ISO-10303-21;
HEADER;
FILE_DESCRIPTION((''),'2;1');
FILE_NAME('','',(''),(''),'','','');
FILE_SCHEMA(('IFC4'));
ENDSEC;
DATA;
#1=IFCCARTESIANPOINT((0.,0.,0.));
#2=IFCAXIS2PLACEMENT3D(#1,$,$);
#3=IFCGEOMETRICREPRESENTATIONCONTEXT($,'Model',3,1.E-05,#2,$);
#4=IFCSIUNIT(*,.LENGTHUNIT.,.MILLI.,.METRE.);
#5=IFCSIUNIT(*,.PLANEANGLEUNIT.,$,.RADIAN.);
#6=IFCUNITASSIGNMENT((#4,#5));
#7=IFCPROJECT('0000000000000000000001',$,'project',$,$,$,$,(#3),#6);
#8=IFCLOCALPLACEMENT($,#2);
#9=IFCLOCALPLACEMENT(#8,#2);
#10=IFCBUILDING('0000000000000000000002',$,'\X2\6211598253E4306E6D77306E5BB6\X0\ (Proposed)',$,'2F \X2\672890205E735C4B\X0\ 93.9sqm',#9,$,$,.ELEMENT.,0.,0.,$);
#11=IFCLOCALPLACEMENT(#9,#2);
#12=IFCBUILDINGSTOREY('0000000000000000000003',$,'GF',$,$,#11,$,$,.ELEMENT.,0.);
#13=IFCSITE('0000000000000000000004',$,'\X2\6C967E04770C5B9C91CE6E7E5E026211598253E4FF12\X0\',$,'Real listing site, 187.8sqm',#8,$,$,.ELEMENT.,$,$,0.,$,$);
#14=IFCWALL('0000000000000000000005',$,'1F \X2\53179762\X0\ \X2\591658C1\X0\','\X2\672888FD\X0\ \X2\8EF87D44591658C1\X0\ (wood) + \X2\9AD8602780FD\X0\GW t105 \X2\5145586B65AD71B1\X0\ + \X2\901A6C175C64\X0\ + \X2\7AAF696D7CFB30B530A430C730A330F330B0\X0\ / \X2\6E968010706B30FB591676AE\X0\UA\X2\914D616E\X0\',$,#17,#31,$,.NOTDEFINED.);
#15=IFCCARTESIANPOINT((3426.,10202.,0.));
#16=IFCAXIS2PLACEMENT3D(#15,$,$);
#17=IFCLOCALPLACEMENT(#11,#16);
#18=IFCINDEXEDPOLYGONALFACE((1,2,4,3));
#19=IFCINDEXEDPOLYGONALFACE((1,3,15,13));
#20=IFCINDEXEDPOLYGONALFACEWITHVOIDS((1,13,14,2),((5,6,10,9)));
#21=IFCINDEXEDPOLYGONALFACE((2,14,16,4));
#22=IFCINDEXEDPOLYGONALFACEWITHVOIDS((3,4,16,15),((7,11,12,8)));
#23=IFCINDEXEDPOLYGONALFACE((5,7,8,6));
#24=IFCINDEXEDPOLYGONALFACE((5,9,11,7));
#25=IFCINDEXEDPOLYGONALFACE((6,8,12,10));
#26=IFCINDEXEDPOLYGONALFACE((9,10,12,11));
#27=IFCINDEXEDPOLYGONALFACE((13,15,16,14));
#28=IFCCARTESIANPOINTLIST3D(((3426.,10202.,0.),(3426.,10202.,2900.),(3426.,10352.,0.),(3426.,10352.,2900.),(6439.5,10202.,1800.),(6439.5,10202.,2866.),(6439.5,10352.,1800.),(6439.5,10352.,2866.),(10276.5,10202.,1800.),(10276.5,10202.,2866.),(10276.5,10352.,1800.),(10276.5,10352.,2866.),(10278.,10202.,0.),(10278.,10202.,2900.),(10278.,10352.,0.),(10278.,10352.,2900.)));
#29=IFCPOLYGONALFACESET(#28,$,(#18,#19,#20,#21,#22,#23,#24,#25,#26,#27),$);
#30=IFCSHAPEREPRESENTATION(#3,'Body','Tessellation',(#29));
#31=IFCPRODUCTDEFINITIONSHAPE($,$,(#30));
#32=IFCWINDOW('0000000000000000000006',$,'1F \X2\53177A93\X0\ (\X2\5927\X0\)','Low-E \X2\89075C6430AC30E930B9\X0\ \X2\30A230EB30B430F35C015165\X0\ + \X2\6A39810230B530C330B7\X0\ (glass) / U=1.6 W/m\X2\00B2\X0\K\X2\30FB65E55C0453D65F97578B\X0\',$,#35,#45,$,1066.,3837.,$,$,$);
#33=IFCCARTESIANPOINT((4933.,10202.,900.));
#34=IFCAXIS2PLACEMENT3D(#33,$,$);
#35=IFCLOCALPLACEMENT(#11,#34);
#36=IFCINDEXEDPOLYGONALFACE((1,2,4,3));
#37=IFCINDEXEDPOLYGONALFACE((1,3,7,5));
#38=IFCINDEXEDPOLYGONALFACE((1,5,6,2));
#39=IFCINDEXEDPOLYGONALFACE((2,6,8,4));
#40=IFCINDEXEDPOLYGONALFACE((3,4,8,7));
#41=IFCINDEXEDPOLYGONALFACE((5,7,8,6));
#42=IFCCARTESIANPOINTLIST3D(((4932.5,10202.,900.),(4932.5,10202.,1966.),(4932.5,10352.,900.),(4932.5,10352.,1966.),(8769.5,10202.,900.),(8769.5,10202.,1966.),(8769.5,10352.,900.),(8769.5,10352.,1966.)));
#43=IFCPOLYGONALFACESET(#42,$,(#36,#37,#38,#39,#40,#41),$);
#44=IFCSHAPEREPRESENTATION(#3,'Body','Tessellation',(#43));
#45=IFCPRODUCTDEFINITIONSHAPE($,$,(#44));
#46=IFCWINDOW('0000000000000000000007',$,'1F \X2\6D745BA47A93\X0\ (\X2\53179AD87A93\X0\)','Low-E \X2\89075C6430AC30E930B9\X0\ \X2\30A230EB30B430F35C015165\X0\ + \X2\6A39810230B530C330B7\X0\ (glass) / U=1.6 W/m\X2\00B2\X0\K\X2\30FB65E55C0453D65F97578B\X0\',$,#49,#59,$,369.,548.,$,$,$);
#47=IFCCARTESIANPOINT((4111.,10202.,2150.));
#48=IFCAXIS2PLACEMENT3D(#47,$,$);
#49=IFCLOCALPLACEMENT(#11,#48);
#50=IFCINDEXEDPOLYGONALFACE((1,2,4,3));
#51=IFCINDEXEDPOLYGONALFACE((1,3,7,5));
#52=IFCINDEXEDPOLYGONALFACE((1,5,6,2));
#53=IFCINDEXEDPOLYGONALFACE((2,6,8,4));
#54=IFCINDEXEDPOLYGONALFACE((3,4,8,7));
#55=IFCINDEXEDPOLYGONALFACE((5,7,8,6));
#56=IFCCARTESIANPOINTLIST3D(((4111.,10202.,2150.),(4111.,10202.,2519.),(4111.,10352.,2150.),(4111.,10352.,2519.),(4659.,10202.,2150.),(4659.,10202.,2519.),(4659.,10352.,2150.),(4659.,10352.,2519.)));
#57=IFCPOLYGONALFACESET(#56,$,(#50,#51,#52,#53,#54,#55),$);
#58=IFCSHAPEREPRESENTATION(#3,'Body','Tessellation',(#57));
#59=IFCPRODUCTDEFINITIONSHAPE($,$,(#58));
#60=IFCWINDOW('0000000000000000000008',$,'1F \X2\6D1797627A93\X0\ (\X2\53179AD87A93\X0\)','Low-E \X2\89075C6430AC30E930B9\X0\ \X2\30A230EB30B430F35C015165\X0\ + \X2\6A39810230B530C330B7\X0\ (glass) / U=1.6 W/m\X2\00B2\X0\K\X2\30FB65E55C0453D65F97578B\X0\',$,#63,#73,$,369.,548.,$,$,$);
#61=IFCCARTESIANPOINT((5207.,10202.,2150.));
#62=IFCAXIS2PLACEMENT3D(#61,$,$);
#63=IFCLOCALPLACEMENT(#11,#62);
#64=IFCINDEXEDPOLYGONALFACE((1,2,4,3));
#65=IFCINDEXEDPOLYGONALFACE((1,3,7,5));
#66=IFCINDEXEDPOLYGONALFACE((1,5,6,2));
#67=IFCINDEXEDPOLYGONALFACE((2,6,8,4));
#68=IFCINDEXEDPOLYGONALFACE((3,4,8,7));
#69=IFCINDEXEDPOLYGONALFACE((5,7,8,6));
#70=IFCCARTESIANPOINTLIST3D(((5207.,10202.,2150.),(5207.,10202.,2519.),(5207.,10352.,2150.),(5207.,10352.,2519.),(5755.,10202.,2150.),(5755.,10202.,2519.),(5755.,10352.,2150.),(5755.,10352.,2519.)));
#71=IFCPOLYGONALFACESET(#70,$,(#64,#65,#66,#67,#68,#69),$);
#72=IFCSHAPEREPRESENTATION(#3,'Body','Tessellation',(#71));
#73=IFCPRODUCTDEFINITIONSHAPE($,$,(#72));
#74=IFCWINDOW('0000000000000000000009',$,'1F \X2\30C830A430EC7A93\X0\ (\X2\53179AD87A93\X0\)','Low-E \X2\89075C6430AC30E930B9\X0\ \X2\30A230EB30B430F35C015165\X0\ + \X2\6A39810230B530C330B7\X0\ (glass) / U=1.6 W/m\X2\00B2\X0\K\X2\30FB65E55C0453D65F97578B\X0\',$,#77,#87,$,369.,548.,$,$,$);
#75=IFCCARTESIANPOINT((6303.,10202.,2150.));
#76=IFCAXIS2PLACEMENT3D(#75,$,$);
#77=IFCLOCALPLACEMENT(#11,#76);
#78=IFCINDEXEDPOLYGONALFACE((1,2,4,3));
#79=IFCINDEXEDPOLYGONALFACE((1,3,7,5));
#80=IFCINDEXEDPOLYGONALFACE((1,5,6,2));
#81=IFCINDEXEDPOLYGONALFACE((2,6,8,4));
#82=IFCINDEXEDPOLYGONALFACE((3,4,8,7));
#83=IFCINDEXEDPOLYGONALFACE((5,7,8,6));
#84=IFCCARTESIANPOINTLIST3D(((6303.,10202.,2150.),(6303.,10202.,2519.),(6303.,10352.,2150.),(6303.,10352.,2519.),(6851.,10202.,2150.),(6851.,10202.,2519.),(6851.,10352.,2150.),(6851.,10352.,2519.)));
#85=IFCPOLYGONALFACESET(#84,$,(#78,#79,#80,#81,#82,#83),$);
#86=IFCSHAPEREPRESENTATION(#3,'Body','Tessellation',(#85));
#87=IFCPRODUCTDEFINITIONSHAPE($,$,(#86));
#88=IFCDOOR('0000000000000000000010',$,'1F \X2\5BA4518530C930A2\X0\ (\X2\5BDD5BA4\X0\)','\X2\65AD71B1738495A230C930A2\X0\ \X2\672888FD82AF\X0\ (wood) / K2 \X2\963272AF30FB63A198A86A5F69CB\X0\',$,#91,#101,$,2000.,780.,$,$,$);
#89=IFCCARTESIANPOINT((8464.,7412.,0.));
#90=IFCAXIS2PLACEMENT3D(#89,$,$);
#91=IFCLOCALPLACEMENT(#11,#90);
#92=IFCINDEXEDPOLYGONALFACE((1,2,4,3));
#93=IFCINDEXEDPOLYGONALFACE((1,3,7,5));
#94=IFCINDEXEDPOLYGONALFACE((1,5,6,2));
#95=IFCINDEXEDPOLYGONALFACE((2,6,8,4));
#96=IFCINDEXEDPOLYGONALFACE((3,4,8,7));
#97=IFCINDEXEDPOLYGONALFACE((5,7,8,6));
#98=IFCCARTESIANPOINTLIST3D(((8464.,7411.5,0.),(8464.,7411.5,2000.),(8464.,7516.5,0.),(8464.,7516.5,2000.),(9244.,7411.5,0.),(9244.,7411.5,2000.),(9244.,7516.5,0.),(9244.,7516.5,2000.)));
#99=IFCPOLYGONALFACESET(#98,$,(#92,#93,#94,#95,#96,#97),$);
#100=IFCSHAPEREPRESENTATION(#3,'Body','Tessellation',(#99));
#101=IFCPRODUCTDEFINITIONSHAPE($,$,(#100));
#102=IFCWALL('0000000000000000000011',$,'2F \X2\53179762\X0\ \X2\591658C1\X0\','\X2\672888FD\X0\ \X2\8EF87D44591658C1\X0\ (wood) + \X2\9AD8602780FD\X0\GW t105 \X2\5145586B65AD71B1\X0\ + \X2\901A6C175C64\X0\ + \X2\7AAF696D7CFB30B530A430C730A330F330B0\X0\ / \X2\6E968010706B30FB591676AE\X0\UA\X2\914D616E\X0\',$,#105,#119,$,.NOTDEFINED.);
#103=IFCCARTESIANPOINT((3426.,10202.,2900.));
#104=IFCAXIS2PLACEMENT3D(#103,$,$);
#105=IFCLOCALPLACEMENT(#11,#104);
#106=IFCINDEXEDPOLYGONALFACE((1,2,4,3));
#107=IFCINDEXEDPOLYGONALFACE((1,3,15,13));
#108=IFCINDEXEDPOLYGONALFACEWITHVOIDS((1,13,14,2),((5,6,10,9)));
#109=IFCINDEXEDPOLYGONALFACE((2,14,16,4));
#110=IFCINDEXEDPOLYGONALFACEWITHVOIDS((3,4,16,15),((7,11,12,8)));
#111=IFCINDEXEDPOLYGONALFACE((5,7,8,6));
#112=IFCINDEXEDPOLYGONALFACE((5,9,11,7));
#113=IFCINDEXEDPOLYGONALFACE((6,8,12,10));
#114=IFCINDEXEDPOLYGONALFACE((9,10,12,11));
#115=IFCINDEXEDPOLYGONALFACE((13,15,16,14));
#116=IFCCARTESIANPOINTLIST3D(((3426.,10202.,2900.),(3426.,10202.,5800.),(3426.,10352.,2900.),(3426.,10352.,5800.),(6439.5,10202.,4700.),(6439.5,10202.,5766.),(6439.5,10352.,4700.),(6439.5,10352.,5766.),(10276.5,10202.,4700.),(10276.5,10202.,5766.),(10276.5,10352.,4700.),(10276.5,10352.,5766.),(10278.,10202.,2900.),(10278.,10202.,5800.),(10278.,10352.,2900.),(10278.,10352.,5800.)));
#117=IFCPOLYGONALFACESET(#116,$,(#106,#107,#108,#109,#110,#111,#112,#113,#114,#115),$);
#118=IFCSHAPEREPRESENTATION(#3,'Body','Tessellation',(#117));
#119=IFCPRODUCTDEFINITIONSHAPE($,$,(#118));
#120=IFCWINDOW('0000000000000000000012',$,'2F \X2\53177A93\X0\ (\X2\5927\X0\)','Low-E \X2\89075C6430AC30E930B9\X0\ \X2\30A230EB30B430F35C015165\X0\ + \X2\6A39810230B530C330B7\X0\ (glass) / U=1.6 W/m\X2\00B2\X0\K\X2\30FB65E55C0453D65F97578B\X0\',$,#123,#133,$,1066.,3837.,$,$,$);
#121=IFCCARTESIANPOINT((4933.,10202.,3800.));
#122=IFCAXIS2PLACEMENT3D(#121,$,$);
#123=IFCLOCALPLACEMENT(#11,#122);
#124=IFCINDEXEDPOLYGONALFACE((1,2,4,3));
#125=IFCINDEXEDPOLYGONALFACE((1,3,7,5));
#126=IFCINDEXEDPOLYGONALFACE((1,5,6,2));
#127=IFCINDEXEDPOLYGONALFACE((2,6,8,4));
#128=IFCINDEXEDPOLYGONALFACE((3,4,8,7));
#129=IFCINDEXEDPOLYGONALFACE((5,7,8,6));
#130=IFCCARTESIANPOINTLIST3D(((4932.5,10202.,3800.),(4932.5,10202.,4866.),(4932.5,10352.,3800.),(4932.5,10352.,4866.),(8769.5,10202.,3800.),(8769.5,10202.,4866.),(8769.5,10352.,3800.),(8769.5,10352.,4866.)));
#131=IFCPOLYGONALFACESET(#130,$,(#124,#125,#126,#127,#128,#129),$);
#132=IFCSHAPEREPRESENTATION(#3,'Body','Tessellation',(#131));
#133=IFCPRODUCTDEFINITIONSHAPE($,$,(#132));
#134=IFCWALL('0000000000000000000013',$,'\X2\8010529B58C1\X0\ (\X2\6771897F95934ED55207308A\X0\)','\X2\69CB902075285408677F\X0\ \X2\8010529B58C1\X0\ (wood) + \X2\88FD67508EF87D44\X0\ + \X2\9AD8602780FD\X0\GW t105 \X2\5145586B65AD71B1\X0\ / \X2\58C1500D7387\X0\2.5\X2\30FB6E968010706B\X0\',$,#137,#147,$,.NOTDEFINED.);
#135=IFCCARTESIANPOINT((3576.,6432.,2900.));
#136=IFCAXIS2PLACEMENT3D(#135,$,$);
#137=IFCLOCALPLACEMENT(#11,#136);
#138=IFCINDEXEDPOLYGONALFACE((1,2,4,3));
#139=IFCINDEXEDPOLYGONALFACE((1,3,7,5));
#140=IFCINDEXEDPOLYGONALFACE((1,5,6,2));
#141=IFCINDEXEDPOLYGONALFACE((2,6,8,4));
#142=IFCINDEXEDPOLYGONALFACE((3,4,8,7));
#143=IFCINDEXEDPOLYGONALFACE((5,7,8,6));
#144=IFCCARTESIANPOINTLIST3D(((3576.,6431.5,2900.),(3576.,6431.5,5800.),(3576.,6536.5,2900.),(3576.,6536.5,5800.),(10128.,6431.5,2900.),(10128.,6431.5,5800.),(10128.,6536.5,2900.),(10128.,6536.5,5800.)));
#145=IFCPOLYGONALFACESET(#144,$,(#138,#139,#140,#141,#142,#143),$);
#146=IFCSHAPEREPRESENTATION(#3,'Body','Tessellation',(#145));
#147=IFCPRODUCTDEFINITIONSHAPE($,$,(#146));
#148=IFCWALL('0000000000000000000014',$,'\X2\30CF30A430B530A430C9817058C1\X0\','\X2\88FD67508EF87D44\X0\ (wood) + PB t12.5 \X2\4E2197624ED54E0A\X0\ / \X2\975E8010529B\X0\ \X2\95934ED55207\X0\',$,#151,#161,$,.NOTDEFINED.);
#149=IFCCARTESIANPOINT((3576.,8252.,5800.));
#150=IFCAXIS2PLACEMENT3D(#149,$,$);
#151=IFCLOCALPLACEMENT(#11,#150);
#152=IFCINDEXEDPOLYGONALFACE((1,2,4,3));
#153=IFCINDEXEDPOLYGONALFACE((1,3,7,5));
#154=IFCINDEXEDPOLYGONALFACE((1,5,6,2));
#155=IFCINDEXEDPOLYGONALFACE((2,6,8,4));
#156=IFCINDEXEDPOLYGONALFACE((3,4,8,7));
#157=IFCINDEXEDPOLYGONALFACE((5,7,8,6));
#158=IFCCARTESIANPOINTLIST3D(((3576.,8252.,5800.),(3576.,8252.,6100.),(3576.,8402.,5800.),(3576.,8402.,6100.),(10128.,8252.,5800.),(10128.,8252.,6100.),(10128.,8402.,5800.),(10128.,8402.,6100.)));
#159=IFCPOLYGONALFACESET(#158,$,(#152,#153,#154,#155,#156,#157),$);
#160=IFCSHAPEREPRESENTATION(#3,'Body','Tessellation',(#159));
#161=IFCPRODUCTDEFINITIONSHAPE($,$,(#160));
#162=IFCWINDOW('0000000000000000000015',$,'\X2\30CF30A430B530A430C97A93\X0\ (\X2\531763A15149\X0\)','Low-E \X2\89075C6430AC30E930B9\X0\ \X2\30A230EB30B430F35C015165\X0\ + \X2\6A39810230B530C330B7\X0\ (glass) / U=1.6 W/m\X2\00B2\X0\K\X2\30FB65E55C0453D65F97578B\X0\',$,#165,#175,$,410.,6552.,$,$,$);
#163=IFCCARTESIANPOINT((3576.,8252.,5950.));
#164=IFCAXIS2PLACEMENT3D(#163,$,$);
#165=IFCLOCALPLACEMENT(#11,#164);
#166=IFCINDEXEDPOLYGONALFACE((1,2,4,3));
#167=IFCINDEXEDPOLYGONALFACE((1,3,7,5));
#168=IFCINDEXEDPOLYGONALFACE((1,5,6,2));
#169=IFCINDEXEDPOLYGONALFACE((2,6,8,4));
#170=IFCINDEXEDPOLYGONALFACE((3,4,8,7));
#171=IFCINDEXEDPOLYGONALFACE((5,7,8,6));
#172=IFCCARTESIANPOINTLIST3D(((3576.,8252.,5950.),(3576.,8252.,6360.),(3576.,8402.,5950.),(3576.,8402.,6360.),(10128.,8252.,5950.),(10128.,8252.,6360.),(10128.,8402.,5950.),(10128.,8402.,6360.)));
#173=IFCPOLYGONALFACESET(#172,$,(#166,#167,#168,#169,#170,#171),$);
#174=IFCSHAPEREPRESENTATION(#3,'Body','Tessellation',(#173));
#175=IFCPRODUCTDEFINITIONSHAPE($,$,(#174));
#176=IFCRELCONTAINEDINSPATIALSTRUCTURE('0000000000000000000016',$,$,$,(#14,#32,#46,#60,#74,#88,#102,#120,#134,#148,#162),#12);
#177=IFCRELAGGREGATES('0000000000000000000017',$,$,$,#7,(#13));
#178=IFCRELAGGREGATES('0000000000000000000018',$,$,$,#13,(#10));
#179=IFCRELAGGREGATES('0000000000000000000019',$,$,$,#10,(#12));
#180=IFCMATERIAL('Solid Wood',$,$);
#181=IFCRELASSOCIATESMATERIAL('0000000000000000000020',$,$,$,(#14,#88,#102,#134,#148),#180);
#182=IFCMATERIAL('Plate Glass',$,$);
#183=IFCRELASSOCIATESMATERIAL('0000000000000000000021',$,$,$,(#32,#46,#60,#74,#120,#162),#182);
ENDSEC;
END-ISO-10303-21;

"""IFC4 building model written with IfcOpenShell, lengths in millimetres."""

from ifc_helpers import new_model, si_unit, frame, frame_2d, origin, place, context, project, spatial, rectangle, extrude, material, element, fill, save


model = new_model("IFC4")

# Units and contexts
model_context = context("Model", 3, precision=1e-05, world=origin())
ifc_project = project(units=[si_unit("LENGTHUNIT", "METRE", prefix="MILLI"), si_unit("PLANEANGLEUNIT", "RADIAN")], contexts=[model_context])

# Site, building, storey
site_placement = place(None, origin())
site = spatial("IfcSite", under=ifc_project, at=site_placement, Name="沖縄県宜野湾市我如古２", ObjectType="Real listing site, 187.8sqm", CompositionType="ELEMENT", RefElevation=0.0)
building_placement = place(site_placement, origin())
building = spatial("IfcBuilding", under=site, at=building_placement, Name="我如古の海の家 (Proposed)", ObjectType="2F 木造平屋 93.9sqm", CompositionType="ELEMENT", ElevationOfRefHeight=0.0, ElevationOfTerrain=0.0)
storey_placement = place(building_placement, origin())
storey = spatial("IfcBuildingStorey", under=building, at=storey_placement, Name="GF", CompositionType="ELEMENT", Elevation=0.0)

# Wall, openings, windows
ifc_material_1 = material(Name="Solid Wood")
wall_1_placement = place(storey_placement, frame((3426.0, 10202.0, 0.0)))
wall_1 = element("IfcWall", 1, at=wall_1_placement, inside=storey, material=ifc_material_1, Name="1F 北面 外壁", Description="木製 軸組外壁 (wood) + 高性能GW t105 充填断熱 + 通気層 + 窯業系サイディング / 準耐火・外皮UA配慮", PredefinedType="NOTDEFINED", context=model_context, shape_type="SweptSolid", body=[
    extrude(rectangle(XDim=6852.0, YDim=150.0, at=frame_2d((3426.0, 75.0))), frame((3426.0, 10202.0, 0.0)), (0.0, 0.0, 1.0), 2900.0),
])
opening_1_placement = place(storey_placement, frame((4933.0, 10202.0, 900.0)))
opening_1 = element("IfcOpeningElement", 2, at=opening_1_placement, cuts=wall_1, PredefinedType="NOTDEFINED", context=model_context, shape_type="SweptSolid", body=[
    extrude(rectangle(XDim=3837.0, YDim=150.0, at=frame_2d((1918.0, 75.0))), frame((4933.0, 10202.0, 900.0)), (0.0, 0.0, 1.0), 1066.0),
])
opening_2_placement = place(storey_placement, frame((4111.0, 10202.0, 2150.0)))
opening_2 = element("IfcOpeningElement", 3, at=opening_2_placement, cuts=wall_1, PredefinedType="NOTDEFINED", context=model_context, shape_type="SweptSolid", body=[
    extrude(rectangle(XDim=548.0, YDim=150.0, at=frame_2d((274.0, 75.0))), frame((4111.0, 10202.0, 2150.0)), (0.0, 0.0, 1.0), 369.0),
])
opening_3_placement = place(storey_placement, frame((5207.0, 10202.0, 2150.0)))
opening_3 = element("IfcOpeningElement", 4, at=opening_3_placement, cuts=wall_1, PredefinedType="NOTDEFINED", context=model_context, shape_type="SweptSolid", body=[
    extrude(rectangle(XDim=548.0, YDim=150.0, at=frame_2d((274.0, 75.0))), frame((5207.0, 10202.0, 2150.0)), (0.0, 0.0, 1.0), 369.0),
])
opening_4_placement = place(storey_placement, frame((6303.0, 10202.0, 2150.0)))
opening_4 = element("IfcOpeningElement", 5, at=opening_4_placement, cuts=wall_1, PredefinedType="NOTDEFINED", context=model_context, shape_type="SweptSolid", body=[
    extrude(rectangle(XDim=548.0, YDim=150.0, at=frame_2d((274.0, 75.0))), frame((6303.0, 10202.0, 2150.0)), (0.0, 0.0, 1.0), 369.0),
])
ifc_material_2 = material(Name="Plate Glass")
window_1_placement = place(storey_placement, frame((4933.0, 10202.0, 900.0)))
window_1 = element("IfcWindow", 6, at=window_1_placement, inside=storey, material=ifc_material_2, Name="1F 北窓 (大)", Description="Low-E 複層ガラス アルゴン封入 + 樹脂サッシ (glass) / U=1.6 W/m²K・日射取得型", OverallHeight=1066.0, OverallWidth=3837.0, context=model_context, shape_type="SweptSolid", body=[
    extrude(rectangle(XDim=3837.0, YDim=150.0, at=frame_2d((1918.0, 75.0))), frame((4933.0, 10202.0, 900.0)), (0.0, 0.0, 1.0), 1066.0),
])
fill(opening_1, window_1)
window_2_placement = place(storey_placement, frame((4111.0, 10202.0, 2150.0)))
window_2 = element("IfcWindow", 7, at=window_2_placement, inside=storey, material=ifc_material_2, Name="1F 浴室窓 (北高窓)", Description="Low-E 複層ガラス アルゴン封入 + 樹脂サッシ (glass) / U=1.6 W/m²K・日射取得型", OverallHeight=369.0, OverallWidth=548.0, context=model_context, shape_type="SweptSolid", body=[
    extrude(rectangle(XDim=548.0, YDim=150.0, at=frame_2d((274.0, 75.0))), frame((4111.0, 10202.0, 2150.0)), (0.0, 0.0, 1.0), 369.0),
])
fill(opening_2, window_2)
window_3_placement = place(storey_placement, frame((5207.0, 10202.0, 2150.0)))
window_3 = element("IfcWindow", 8, at=window_3_placement, inside=storey, material=ifc_material_2, Name="1F 洗面窓 (北高窓)", Description="Low-E 複層ガラス アルゴン封入 + 樹脂サッシ (glass) / U=1.6 W/m²K・日射取得型", OverallHeight=369.0, OverallWidth=548.0, context=model_context, shape_type="SweptSolid", body=[
    extrude(rectangle(XDim=548.0, YDim=150.0, at=frame_2d((274.0, 75.0))), frame((5207.0, 10202.0, 2150.0)), (0.0, 0.0, 1.0), 369.0),
])
fill(opening_3, window_3)
window_4_placement = place(storey_placement, frame((6303.0, 10202.0, 2150.0)))
window_4 = element("IfcWindow", 9, at=window_4_placement, inside=storey, material=ifc_material_2, Name="1F トイレ窓 (北高窓)", Description="Low-E 複層ガラス アルゴン封入 + 樹脂サッシ (glass) / U=1.6 W/m²K・日射取得型", OverallHeight=369.0, OverallWidth=548.0, context=model_context, shape_type="SweptSolid", body=[
    extrude(rectangle(XDim=548.0, YDim=150.0, at=frame_2d((274.0, 75.0))), frame((6303.0, 10202.0, 2150.0)), (0.0, 0.0, 1.0), 369.0),
])
fill(opening_4, window_4)

# Door
door_1_placement = place(storey_placement, frame((8464.0, 7412.0, 0.0)))
element("IfcDoor", 10, at=door_1_placement, inside=storey, material=ifc_material_1, Name="1F 室内ドア (寝室)", Description="断熱玄関ドア 木製芯 (wood) / K2 防犯・採風機構", OverallHeight=2000.0, OverallWidth=780.0, context=model_context, shape_type="SweptSolid", body=[
    extrude(rectangle(XDim=780.0, YDim=105.0, at=frame_2d((390.0, 52.0))), frame((8464.0, 7412.0, 0.0)), (0.0, 0.0, 1.0), 2000.0),
])

# Wall, opening, window
wall_2_placement = place(storey_placement, frame((3426.0, 10202.0, 2900.0)))
wall_2 = element("IfcWall", 11, at=wall_2_placement, inside=storey, material=ifc_material_1, Name="2F 北面 外壁", Description="木製 軸組外壁 (wood) + 高性能GW t105 充填断熱 + 通気層 + 窯業系サイディング / 準耐火・外皮UA配慮", PredefinedType="NOTDEFINED", context=model_context, shape_type="SweptSolid", body=[
    extrude(rectangle(XDim=6852.0, YDim=150.0, at=frame_2d((3426.0, 75.0))), frame((3426.0, 10202.0, 2900.0)), (0.0, 0.0, 1.0), 2900.0),
])
opening_5_placement = place(storey_placement, frame((4933.0, 10202.0, 3800.0)))
opening_5 = element("IfcOpeningElement", 12, at=opening_5_placement, cuts=wall_2, PredefinedType="NOTDEFINED", context=model_context, shape_type="SweptSolid", body=[
    extrude(rectangle(XDim=3837.0, YDim=150.0, at=frame_2d((1918.0, 75.0))), frame((4933.0, 10202.0, 3800.0)), (0.0, 0.0, 1.0), 1066.0),
])
window_5_placement = place(storey_placement, frame((4933.0, 10202.0, 3800.0)))
window_5 = element("IfcWindow", 13, at=window_5_placement, inside=storey, material=ifc_material_2, Name="2F 北窓 (大)", Description="Low-E 複層ガラス アルゴン封入 + 樹脂サッシ (glass) / U=1.6 W/m²K・日射取得型", OverallHeight=1066.0, OverallWidth=3837.0, context=model_context, shape_type="SweptSolid", body=[
    extrude(rectangle(XDim=3837.0, YDim=150.0, at=frame_2d((1918.0, 75.0))), frame((4933.0, 10202.0, 3800.0)), (0.0, 0.0, 1.0), 1066.0),
])
fill(opening_5, window_5)

# Wall
wall_3_placement = place(storey_placement, frame((3576.0, 6432.0, 2900.0)))
element("IfcWall", 14, at=wall_3_placement, inside=storey, material=ifc_material_1, Name="耐力壁 (東西間仕切り)", Description="構造用合板 耐力壁 (wood) + 製材軸組 + 高性能GW t105 充填断熱 / 壁倍率2.5・準耐火", PredefinedType="NOTDEFINED", context=model_context, shape_type="SweptSolid", body=[
    extrude(rectangle(XDim=6552.0, YDim=105.0, at=frame_2d((3276.0, 52.0))), frame((3576.0, 6432.0, 2900.0)), (0.0, 0.0, 1.0), 2900.0),
])

# Wall, opening, window
wall_4_placement = place(storey_placement, frame((3576.0, 8252.0, 5800.0)))
wall_4 = element("IfcWall", 15, at=wall_4_placement, inside=storey, material=ifc_material_1, Name="ハイサイド腰壁", Description="製材軸組 (wood) + PB t12.5 両面仕上 / 非耐力 間仕切", PredefinedType="NOTDEFINED", context=model_context, shape_type="SweptSolid", body=[
    extrude(rectangle(XDim=6552.0, YDim=150.0, at=frame_2d((3276.0, 75.0))), frame((3576.0, 8252.0, 5800.0)), (0.0, 0.0, 1.0), 700.0),
])
opening_6_placement = place(storey_placement, frame((3576.0, 8252.0, 5950.0)))
opening_6 = element("IfcOpeningElement", 16, at=opening_6_placement, cuts=wall_4, PredefinedType="NOTDEFINED", context=model_context, shape_type="SweptSolid", body=[
    extrude(rectangle(XDim=6552.0, YDim=150.0, at=frame_2d((3276.0, 75.0))), frame((3576.0, 8252.0, 5950.0)), (0.0, 0.0, 1.0), 410.0),
])
window_6_placement = place(storey_placement, frame((3576.0, 8252.0, 5950.0)))
window_6 = element("IfcWindow", 17, at=window_6_placement, inside=storey, material=ifc_material_2, Name="ハイサイド窓 (北採光)", Description="Low-E 複層ガラス アルゴン封入 + 樹脂サッシ (glass) / U=1.6 W/m²K・日射取得型", OverallHeight=410.0, OverallWidth=6552.0, context=model_context, shape_type="SweptSolid", body=[
    extrude(rectangle(XDim=6552.0, YDim=150.0, at=frame_2d((3276.0, 75.0))), frame((3576.0, 8252.0, 5950.0)), (0.0, 0.0, 1.0), 410.0),
])
fill(opening_6, window_6)

save(model, "model.ifc")
